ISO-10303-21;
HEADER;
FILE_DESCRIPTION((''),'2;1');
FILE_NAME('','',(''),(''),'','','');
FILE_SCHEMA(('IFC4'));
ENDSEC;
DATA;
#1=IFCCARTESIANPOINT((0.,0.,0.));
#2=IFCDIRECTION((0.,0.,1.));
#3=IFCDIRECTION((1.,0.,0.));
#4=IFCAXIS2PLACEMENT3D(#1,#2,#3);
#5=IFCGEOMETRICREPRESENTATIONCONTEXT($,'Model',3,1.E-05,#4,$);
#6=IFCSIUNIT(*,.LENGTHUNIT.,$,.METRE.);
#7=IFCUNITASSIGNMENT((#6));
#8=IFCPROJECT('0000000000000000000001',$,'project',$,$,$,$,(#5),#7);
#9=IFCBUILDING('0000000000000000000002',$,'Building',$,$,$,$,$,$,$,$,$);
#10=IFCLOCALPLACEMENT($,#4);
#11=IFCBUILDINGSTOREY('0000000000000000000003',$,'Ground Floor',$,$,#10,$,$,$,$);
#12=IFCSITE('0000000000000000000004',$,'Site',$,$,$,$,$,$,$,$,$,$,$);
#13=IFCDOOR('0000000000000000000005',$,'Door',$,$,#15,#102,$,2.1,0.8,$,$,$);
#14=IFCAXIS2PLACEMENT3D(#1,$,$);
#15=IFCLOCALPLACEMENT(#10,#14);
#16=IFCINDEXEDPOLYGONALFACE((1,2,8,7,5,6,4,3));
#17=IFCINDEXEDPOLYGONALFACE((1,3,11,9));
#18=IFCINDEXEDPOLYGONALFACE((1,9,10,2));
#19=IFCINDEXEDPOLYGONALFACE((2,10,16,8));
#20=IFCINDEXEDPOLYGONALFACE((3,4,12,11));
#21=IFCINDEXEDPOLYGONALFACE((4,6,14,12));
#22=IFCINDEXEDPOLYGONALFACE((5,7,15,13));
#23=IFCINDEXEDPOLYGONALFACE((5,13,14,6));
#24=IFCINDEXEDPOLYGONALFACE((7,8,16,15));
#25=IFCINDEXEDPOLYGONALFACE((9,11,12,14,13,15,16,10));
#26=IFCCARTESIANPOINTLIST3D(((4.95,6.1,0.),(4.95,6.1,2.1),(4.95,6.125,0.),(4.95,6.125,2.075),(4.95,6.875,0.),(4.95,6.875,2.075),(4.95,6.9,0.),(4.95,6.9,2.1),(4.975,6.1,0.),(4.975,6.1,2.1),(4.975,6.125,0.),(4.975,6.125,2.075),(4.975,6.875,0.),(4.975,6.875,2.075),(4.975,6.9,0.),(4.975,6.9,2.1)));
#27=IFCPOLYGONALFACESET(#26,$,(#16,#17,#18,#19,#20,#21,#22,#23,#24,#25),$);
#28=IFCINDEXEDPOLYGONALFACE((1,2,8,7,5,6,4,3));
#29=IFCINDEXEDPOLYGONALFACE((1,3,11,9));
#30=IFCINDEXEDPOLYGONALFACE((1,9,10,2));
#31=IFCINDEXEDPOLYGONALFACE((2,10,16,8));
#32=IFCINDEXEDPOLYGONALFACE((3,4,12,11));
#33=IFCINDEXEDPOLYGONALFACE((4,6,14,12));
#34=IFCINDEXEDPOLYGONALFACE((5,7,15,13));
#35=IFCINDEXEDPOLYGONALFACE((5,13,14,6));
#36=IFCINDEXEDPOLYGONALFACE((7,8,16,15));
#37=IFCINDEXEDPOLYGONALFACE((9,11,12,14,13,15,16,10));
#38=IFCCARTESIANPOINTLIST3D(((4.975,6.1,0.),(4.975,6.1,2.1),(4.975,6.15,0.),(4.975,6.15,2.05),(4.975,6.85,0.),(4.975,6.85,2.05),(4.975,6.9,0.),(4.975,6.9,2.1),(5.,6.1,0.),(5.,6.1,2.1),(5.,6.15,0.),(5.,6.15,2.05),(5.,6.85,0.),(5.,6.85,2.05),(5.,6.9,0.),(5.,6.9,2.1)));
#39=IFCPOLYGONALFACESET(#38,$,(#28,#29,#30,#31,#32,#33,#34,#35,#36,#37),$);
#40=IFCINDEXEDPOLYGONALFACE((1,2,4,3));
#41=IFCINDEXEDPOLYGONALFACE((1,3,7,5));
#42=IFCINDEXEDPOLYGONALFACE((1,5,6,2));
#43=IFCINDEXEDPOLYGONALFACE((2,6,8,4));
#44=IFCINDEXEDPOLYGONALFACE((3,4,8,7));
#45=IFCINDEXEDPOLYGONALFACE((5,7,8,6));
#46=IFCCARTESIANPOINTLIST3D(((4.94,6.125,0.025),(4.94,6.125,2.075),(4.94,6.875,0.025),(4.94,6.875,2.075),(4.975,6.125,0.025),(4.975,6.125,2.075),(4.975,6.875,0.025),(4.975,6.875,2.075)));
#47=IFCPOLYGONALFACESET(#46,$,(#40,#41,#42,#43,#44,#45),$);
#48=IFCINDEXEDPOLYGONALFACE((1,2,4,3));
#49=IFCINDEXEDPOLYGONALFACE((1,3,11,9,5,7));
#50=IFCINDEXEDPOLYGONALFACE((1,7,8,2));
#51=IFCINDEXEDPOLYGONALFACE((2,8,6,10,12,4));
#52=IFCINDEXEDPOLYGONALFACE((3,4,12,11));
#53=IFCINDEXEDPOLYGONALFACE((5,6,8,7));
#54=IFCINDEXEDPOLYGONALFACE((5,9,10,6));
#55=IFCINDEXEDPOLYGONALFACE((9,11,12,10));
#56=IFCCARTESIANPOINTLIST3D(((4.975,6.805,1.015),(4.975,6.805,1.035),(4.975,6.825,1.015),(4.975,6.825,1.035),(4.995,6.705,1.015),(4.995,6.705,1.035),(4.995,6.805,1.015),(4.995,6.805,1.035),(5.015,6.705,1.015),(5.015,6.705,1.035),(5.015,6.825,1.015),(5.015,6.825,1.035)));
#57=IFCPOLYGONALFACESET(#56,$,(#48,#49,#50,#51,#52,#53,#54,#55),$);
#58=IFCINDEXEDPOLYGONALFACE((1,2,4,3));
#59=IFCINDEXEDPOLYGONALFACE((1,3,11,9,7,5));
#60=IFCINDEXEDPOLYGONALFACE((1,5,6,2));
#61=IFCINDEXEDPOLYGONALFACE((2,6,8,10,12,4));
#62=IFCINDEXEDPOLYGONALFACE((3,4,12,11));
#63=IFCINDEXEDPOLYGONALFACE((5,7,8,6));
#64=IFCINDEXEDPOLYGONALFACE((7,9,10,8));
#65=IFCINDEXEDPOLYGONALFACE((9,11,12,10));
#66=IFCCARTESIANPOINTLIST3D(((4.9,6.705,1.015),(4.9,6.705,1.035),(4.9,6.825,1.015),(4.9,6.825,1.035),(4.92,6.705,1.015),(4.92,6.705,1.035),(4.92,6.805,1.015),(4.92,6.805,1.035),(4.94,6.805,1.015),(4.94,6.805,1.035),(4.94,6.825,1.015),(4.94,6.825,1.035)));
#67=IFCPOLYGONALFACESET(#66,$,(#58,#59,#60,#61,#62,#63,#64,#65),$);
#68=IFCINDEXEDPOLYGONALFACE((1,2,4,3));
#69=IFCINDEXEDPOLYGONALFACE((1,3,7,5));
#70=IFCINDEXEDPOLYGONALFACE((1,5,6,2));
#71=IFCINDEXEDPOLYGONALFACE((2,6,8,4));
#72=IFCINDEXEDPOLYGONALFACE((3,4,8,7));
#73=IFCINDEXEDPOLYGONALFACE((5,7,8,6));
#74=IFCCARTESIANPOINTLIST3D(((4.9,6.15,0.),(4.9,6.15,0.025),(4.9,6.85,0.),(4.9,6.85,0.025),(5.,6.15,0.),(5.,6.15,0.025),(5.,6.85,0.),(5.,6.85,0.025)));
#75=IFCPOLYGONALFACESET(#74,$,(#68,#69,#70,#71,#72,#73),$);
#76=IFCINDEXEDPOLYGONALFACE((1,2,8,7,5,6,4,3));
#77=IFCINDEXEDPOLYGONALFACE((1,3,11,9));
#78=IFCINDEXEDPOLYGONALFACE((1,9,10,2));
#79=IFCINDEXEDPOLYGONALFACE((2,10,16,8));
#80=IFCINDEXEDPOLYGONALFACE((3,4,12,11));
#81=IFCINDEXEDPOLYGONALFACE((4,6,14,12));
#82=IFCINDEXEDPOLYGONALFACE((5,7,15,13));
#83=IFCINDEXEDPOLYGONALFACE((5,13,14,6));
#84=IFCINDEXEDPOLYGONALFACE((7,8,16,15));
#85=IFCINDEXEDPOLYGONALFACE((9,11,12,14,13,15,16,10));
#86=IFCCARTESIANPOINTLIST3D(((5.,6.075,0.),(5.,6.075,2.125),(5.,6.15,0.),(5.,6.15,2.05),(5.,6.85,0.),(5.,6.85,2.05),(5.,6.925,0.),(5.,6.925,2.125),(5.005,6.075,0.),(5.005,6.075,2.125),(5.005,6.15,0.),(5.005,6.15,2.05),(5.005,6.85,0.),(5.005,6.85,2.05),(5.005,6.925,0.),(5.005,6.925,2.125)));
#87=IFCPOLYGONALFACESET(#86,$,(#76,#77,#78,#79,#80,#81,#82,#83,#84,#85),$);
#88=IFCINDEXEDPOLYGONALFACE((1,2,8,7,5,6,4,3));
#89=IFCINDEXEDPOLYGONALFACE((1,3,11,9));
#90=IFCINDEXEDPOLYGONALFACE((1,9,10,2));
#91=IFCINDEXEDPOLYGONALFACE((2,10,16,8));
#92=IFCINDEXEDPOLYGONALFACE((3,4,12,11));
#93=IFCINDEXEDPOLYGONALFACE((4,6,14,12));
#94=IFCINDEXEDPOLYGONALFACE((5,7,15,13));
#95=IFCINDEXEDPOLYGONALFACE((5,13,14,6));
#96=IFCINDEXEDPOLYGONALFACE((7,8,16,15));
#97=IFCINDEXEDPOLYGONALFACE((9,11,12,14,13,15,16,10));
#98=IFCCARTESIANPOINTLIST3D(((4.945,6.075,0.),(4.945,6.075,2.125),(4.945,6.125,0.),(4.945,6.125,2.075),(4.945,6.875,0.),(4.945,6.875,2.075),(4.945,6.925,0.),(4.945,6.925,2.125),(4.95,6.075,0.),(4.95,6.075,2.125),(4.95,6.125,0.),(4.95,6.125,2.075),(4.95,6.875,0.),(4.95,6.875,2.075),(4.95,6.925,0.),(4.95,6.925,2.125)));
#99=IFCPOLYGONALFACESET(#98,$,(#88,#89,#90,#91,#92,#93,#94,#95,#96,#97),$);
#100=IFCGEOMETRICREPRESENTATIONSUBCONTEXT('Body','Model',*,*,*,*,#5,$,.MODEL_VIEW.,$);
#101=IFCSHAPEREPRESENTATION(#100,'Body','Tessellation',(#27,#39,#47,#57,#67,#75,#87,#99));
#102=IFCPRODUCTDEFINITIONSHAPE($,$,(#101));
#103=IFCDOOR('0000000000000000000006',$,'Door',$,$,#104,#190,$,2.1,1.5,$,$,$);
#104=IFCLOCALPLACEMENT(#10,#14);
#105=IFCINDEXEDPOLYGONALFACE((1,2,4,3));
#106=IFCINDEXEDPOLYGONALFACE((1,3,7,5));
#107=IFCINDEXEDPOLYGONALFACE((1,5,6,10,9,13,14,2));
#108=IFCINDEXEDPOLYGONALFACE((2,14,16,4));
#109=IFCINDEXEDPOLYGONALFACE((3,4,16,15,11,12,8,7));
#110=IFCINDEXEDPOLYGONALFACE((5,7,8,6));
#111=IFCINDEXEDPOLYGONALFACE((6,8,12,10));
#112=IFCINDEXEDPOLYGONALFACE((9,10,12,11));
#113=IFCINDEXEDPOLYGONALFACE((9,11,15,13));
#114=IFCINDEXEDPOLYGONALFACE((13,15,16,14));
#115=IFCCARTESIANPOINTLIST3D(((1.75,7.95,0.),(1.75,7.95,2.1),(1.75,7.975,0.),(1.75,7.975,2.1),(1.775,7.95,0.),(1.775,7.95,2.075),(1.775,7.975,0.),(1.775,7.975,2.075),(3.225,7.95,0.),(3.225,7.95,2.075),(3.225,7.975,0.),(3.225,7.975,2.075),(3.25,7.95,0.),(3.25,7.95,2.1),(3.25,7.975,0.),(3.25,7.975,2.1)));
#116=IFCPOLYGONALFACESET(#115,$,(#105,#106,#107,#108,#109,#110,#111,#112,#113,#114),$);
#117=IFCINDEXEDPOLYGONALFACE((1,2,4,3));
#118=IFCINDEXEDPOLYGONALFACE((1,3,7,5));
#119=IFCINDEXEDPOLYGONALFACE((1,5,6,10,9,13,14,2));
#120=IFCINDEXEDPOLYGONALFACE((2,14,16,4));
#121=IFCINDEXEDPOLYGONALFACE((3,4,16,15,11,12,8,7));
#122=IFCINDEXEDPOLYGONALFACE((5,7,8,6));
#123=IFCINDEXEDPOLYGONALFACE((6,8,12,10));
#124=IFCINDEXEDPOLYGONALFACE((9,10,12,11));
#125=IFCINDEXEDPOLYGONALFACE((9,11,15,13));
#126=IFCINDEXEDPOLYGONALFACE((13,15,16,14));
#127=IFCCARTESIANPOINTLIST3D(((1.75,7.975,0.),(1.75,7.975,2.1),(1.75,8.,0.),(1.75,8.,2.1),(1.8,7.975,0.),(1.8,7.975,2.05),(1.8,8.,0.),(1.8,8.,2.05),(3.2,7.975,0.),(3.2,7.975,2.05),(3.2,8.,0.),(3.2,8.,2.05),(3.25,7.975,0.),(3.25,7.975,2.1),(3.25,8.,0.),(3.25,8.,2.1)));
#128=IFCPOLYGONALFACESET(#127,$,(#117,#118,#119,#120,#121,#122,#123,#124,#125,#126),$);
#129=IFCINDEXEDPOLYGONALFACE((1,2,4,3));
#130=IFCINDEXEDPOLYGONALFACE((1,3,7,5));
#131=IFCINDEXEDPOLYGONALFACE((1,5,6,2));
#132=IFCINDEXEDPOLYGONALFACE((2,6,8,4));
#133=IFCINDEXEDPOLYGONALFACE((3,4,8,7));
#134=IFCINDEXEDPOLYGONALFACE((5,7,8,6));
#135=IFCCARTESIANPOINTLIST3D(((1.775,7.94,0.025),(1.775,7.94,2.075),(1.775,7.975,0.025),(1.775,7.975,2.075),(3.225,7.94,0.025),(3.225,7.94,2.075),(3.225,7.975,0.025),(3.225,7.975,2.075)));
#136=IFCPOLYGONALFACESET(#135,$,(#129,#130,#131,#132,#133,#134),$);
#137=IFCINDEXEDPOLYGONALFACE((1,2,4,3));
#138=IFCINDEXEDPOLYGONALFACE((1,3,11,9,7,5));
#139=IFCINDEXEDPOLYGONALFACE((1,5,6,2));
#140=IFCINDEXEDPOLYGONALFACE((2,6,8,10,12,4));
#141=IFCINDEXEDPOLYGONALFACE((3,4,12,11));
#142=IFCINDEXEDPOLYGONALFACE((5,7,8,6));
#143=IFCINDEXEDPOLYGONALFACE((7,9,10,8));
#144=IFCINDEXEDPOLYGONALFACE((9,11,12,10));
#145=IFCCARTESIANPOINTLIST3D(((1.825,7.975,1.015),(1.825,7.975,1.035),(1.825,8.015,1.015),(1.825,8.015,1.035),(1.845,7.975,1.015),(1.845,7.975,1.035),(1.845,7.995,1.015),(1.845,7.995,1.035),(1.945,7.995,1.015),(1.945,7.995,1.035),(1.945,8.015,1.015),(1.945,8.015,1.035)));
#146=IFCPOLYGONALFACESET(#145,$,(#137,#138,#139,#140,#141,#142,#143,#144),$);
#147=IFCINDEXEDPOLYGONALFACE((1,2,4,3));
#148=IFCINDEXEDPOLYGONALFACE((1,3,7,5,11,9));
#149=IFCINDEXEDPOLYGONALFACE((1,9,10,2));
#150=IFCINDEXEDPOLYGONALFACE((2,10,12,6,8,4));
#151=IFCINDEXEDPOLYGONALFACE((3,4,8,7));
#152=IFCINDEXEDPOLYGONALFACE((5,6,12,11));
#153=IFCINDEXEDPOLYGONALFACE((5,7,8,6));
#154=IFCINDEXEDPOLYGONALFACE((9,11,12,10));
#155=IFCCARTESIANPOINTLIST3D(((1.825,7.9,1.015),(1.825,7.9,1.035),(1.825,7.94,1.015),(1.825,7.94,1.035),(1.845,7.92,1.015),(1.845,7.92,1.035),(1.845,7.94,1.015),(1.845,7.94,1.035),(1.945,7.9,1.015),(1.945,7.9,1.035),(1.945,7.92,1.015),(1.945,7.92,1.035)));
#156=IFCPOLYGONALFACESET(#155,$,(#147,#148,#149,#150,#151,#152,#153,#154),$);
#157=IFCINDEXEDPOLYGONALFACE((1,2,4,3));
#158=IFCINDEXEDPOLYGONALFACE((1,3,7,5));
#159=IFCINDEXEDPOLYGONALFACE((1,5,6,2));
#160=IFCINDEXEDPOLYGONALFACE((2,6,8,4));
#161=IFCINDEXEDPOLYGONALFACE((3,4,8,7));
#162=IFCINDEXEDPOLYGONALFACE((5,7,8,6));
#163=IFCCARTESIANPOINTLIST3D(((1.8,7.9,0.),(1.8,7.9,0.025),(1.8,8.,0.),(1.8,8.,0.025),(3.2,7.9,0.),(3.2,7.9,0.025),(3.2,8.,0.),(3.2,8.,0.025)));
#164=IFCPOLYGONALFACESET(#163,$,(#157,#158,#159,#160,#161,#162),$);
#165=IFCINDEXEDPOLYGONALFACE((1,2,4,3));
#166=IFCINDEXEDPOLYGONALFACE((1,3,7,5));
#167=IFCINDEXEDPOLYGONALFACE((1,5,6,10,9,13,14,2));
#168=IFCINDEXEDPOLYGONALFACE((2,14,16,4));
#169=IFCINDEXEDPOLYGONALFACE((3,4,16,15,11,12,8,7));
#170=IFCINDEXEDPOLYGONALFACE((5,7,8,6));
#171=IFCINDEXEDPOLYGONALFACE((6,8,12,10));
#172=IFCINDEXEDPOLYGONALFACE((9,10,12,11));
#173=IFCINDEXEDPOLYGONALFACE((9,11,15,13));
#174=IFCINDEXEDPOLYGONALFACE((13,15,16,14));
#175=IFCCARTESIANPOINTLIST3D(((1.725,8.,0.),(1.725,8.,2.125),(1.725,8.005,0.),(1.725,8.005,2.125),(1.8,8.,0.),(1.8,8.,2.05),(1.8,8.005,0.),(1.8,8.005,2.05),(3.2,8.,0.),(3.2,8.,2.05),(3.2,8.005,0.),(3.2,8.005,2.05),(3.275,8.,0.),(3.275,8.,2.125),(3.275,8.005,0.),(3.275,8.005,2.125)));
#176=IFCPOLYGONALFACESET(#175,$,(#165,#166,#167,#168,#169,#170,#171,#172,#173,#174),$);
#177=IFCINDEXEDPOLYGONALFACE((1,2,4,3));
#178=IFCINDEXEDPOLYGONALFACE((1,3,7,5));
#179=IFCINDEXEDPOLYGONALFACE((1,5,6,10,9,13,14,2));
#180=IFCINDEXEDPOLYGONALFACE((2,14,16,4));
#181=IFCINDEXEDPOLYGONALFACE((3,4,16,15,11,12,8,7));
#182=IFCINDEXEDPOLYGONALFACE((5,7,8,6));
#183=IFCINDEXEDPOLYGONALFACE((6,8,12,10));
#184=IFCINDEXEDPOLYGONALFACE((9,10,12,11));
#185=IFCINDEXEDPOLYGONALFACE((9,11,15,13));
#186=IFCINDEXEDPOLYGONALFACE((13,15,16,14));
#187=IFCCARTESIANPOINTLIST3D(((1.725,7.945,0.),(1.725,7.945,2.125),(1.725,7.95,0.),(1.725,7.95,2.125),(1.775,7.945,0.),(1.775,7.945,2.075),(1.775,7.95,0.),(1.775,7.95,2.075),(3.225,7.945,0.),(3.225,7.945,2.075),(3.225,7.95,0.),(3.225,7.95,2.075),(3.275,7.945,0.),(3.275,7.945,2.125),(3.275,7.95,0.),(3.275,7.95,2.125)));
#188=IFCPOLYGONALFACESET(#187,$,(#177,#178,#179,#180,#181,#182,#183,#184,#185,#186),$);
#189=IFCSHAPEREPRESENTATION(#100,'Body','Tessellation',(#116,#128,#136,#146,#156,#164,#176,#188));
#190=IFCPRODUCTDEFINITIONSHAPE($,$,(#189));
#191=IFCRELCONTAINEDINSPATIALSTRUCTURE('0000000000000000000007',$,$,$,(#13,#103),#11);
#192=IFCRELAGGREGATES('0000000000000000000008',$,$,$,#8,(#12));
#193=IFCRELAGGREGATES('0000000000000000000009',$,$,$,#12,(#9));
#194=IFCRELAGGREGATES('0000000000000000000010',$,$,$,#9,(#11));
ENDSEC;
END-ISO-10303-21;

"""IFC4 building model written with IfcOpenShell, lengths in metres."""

from ifc_helpers import new_model, si_unit, frame, origin_with_axes, place, context, subcontext, project, spatial, line, indexed_curve, outline, extrude, element, save


model = new_model("IFC4")

# Units and contexts
model_context = context("Model", 3, precision=1e-05, world=origin_with_axes())
body_context = subcontext(model_context, "Body", "Model", "MODEL_VIEW")
ifc_project = project(units=[si_unit("LENGTHUNIT", "METRE")], contexts=[model_context])

# Site, building, storey
site = spatial("IfcSite", under=ifc_project, Name="Site")
building = spatial("IfcBuilding", under=site, Name="Building")
storey_placement = place(None, origin_with_axes())
storey = spatial("IfcBuildingStorey", under=building, at=storey_placement, Name="Ground Floor")

# Doors
door_1_placement = place(storey_placement, frame((5.0, 6.1, 0.0), z_axis=(0.0, 0.0, 1.0), x_axis=(0.0, 1.0, 0.0)))
element("IfcDoor", 1, at=door_1_placement, inside=storey, Name="Door", OverallHeight=2.1, OverallWidth=0.8, context=body_context, shape_type="SweptSolid", body=[
    extrude(outline(indexed_curve([(0.0, 0.0), (0.0, 2.1), (0.8, 2.1), (0.8, 0.0), (0.775, 0.0), (0.775, 2.075), (0.025, 2.075), (0.025, 0.0)], segments=[line(1, 2, 3, 4, 5, 6, 7, 8, 1)])), frame((0.0, 0.025, 0.0), z_axis=(0.0, -1.0, 0.0), x_axis=(1.0, 0.0, 0.0)), (0.0, 0.0, -1.0), 0.025),
    extrude(outline(indexed_curve([(0.0, 0.0), (0.0, 2.1), (0.8, 2.1), (0.8, 0.0), (0.75, 0.0), (0.75, 2.05), (0.05, 2.05), (0.05, 0.0)], segments=[line(1, 2, 3, 4, 5, 6, 7, 8, 1)])), frame((0.0, 0.0, 0.0), z_axis=(0.0, -1.0, 0.0), x_axis=(1.0, 0.0, 0.0)), (0.0, 0.0, -1.0), 0.025),
    extrude(outline(indexed_curve([(0.0, 0.0), (0.75, 0.0), (0.75, 0.035), (0.0, 0.035)], segments=[line(1, 2, 3, 4, 1)])), frame((0.025, 0.025, 0.025), z_axis=(0.0, 0.0, 1.0), x_axis=(1.0, 0.0, 0.0)), (0.0, 0.0, 1.0), 2.05),
    extrude(outline(indexed_curve([(0.0, 0.0), (0.0, -0.04), (-0.12, -0.04), (-0.12, -0.02), (-0.02, -0.02), (-0.02, 0.0)], segments=[line(1, 2, 3, 4, 5, 6, 1)])), frame((0.725, 0.025, 1.015), z_axis=(0.0, 0.0, 1.0), x_axis=(1.0, 0.0, 0.0)), (0.0, 0.0, 1.0), 0.02),
    extrude(outline(indexed_curve([(0.0, 0.0), (0.0, 0.04), (-0.12, 0.04), (-0.12, 0.02), (-0.02, 0.02), (-0.02, 0.0)], segments=[line(1, 2, 3, 4, 5, 6, 1)])), frame((0.725, 0.06, 1.015), z_axis=(0.0, 0.0, 1.0), x_axis=(1.0, 0.0, 0.0)), (0.0, 0.0, 1.0), 0.02),
    extrude(outline(indexed_curve([(0.0, 0.0), (0.7, 0.0), (0.7, 0.1), (0.0, 0.1)], segments=[line(1, 2, 3, 4, 1)])), frame((0.05, 0.0, 0.0), z_axis=(0.0, 0.0, 1.0), x_axis=(1.0, 0.0, 0.0)), (0.0, 0.0, 1.0), 0.025),
    extrude(outline(indexed_curve([(0.0, 0.0), (0.0, 2.125), (0.85, 2.125), (0.85, 0.0), (0.775, 0.0), (0.775, 2.05), (0.075, 2.05), (0.075, 0.0)], segments=[line(1, 2, 3, 4, 5, 6, 7, 8, 1)])), frame((-0.025, -0.005, 0.0), z_axis=(0.0, -1.0, 0.0), x_axis=(1.0, 0.0, 0.0)), (0.0, 0.0, -1.0), 0.005),
    extrude(outline(indexed_curve([(0.0, 0.0), (0.0, 2.125), (0.85, 2.125), (0.85, 0.0), (0.8, 0.0), (0.8, 2.075), (0.05, 2.075), (0.05, 0.0)], segments=[line(1, 2, 3, 4, 5, 6, 7, 8, 1)])), frame((-0.025, 0.05, 0.0), z_axis=(0.0, -1.0, 0.0), x_axis=(1.0, 0.0, 0.0)), (0.0, 0.0, -1.0), 0.005),
])
door_2_placement = place(storey_placement, frame((3.25, 8.0, 0.0), z_axis=(0.0, 0.0, 1.0), x_axis=(-1.0, 0.0, 0.0)))
element("IfcDoor", 2, at=door_2_placement, inside=storey, Name="Door", OverallHeight=2.1, OverallWidth=1.5, context=body_context, shape_type="SweptSolid", body=[
    extrude(outline(indexed_curve([(0.0, 0.0), (0.0, 2.1), (1.5, 2.1), (1.5, 0.0), (1.475, 0.0), (1.475, 2.075), (0.025, 2.075), (0.025, 0.0)], segments=[line(1, 2, 3, 4, 5, 6, 7, 8, 1)])), frame((0.0, 0.025, 0.0), z_axis=(0.0, -1.0, 0.0), x_axis=(1.0, 0.0, 0.0)), (0.0, 0.0, -1.0), 0.025),
    extrude(outline(indexed_curve([(0.0, 0.0), (0.0, 2.1), (1.5, 2.1), (1.5, 0.0), (1.45, 0.0), (1.45, 2.05), (0.05, 2.05), (0.05, 0.0)], segments=[line(1, 2, 3, 4, 5, 6, 7, 8, 1)])), frame((0.0, 0.0, 0.0), z_axis=(0.0, -1.0, 0.0), x_axis=(1.0, 0.0, 0.0)), (0.0, 0.0, -1.0), 0.025),
    extrude(outline(indexed_curve([(0.0, 0.0), (1.45, 0.0), (1.45, 0.035), (0.0, 0.035)], segments=[line(1, 2, 3, 4, 1)])), frame((0.025, 0.025, 0.025), z_axis=(0.0, 0.0, 1.0), x_axis=(1.0, 0.0, 0.0)), (0.0, 0.0, 1.0), 2.05),
    extrude(outline(indexed_curve([(0.0, 0.0), (0.0, -0.04), (-0.12, -0.04), (-0.12, -0.02), (-0.02, -0.02), (-0.02, 0.0)], segments=[line(1, 2, 3, 4, 5, 6, 1)])), frame((1.425, 0.025, 1.015), z_axis=(0.0, 0.0, 1.0), x_axis=(1.0, 0.0, 0.0)), (0.0, 0.0, 1.0), 0.02),
    extrude(outline(indexed_curve([(0.0, 0.0), (0.0, 0.04), (-0.12, 0.04), (-0.12, 0.02), (-0.02, 0.02), (-0.02, 0.0)], segments=[line(1, 2, 3, 4, 5, 6, 1)])), frame((1.425, 0.06, 1.015), z_axis=(0.0, 0.0, 1.0), x_axis=(1.0, 0.0, 0.0)), (0.0, 0.0, 1.0), 0.02),
    extrude(outline(indexed_curve([(0.0, 0.0), (1.4, 0.0), (1.4, 0.1), (0.0, 0.1)], segments=[line(1, 2, 3, 4, 1)])), frame((0.05, 0.0, 0.0), z_axis=(0.0, 0.0, 1.0), x_axis=(1.0, 0.0, 0.0)), (0.0, 0.0, 1.0), 0.025),
    extrude(outline(indexed_curve([(0.0, 0.0), (0.0, 2.125), (1.55, 2.125), (1.55, 0.0), (1.475, 0.0), (1.475, 2.05), (0.075, 2.05), (0.075, 0.0)], segments=[line(1, 2, 3, 4, 5, 6, 7, 8, 1)])), frame((-0.025, -0.005, 0.0), z_axis=(0.0, -1.0, 0.0), x_axis=(1.0, 0.0, 0.0)), (0.0, 0.0, -1.0), 0.005),
    extrude(outline(indexed_curve([(0.0, 0.0), (0.0, 2.125), (1.55, 2.125), (1.55, 0.0), (1.5, 0.0), (1.5, 2.075), (0.05, 2.075), (0.05, 0.0)], segments=[line(1, 2, 3, 4, 5, 6, 7, 8, 1)])), frame((-0.025, 0.05, 0.0), z_axis=(0.0, -1.0, 0.0), x_axis=(1.0, 0.0, 0.0)), (0.0, 0.0, -1.0), 0.005),
])

save(model, "model.ifc")
